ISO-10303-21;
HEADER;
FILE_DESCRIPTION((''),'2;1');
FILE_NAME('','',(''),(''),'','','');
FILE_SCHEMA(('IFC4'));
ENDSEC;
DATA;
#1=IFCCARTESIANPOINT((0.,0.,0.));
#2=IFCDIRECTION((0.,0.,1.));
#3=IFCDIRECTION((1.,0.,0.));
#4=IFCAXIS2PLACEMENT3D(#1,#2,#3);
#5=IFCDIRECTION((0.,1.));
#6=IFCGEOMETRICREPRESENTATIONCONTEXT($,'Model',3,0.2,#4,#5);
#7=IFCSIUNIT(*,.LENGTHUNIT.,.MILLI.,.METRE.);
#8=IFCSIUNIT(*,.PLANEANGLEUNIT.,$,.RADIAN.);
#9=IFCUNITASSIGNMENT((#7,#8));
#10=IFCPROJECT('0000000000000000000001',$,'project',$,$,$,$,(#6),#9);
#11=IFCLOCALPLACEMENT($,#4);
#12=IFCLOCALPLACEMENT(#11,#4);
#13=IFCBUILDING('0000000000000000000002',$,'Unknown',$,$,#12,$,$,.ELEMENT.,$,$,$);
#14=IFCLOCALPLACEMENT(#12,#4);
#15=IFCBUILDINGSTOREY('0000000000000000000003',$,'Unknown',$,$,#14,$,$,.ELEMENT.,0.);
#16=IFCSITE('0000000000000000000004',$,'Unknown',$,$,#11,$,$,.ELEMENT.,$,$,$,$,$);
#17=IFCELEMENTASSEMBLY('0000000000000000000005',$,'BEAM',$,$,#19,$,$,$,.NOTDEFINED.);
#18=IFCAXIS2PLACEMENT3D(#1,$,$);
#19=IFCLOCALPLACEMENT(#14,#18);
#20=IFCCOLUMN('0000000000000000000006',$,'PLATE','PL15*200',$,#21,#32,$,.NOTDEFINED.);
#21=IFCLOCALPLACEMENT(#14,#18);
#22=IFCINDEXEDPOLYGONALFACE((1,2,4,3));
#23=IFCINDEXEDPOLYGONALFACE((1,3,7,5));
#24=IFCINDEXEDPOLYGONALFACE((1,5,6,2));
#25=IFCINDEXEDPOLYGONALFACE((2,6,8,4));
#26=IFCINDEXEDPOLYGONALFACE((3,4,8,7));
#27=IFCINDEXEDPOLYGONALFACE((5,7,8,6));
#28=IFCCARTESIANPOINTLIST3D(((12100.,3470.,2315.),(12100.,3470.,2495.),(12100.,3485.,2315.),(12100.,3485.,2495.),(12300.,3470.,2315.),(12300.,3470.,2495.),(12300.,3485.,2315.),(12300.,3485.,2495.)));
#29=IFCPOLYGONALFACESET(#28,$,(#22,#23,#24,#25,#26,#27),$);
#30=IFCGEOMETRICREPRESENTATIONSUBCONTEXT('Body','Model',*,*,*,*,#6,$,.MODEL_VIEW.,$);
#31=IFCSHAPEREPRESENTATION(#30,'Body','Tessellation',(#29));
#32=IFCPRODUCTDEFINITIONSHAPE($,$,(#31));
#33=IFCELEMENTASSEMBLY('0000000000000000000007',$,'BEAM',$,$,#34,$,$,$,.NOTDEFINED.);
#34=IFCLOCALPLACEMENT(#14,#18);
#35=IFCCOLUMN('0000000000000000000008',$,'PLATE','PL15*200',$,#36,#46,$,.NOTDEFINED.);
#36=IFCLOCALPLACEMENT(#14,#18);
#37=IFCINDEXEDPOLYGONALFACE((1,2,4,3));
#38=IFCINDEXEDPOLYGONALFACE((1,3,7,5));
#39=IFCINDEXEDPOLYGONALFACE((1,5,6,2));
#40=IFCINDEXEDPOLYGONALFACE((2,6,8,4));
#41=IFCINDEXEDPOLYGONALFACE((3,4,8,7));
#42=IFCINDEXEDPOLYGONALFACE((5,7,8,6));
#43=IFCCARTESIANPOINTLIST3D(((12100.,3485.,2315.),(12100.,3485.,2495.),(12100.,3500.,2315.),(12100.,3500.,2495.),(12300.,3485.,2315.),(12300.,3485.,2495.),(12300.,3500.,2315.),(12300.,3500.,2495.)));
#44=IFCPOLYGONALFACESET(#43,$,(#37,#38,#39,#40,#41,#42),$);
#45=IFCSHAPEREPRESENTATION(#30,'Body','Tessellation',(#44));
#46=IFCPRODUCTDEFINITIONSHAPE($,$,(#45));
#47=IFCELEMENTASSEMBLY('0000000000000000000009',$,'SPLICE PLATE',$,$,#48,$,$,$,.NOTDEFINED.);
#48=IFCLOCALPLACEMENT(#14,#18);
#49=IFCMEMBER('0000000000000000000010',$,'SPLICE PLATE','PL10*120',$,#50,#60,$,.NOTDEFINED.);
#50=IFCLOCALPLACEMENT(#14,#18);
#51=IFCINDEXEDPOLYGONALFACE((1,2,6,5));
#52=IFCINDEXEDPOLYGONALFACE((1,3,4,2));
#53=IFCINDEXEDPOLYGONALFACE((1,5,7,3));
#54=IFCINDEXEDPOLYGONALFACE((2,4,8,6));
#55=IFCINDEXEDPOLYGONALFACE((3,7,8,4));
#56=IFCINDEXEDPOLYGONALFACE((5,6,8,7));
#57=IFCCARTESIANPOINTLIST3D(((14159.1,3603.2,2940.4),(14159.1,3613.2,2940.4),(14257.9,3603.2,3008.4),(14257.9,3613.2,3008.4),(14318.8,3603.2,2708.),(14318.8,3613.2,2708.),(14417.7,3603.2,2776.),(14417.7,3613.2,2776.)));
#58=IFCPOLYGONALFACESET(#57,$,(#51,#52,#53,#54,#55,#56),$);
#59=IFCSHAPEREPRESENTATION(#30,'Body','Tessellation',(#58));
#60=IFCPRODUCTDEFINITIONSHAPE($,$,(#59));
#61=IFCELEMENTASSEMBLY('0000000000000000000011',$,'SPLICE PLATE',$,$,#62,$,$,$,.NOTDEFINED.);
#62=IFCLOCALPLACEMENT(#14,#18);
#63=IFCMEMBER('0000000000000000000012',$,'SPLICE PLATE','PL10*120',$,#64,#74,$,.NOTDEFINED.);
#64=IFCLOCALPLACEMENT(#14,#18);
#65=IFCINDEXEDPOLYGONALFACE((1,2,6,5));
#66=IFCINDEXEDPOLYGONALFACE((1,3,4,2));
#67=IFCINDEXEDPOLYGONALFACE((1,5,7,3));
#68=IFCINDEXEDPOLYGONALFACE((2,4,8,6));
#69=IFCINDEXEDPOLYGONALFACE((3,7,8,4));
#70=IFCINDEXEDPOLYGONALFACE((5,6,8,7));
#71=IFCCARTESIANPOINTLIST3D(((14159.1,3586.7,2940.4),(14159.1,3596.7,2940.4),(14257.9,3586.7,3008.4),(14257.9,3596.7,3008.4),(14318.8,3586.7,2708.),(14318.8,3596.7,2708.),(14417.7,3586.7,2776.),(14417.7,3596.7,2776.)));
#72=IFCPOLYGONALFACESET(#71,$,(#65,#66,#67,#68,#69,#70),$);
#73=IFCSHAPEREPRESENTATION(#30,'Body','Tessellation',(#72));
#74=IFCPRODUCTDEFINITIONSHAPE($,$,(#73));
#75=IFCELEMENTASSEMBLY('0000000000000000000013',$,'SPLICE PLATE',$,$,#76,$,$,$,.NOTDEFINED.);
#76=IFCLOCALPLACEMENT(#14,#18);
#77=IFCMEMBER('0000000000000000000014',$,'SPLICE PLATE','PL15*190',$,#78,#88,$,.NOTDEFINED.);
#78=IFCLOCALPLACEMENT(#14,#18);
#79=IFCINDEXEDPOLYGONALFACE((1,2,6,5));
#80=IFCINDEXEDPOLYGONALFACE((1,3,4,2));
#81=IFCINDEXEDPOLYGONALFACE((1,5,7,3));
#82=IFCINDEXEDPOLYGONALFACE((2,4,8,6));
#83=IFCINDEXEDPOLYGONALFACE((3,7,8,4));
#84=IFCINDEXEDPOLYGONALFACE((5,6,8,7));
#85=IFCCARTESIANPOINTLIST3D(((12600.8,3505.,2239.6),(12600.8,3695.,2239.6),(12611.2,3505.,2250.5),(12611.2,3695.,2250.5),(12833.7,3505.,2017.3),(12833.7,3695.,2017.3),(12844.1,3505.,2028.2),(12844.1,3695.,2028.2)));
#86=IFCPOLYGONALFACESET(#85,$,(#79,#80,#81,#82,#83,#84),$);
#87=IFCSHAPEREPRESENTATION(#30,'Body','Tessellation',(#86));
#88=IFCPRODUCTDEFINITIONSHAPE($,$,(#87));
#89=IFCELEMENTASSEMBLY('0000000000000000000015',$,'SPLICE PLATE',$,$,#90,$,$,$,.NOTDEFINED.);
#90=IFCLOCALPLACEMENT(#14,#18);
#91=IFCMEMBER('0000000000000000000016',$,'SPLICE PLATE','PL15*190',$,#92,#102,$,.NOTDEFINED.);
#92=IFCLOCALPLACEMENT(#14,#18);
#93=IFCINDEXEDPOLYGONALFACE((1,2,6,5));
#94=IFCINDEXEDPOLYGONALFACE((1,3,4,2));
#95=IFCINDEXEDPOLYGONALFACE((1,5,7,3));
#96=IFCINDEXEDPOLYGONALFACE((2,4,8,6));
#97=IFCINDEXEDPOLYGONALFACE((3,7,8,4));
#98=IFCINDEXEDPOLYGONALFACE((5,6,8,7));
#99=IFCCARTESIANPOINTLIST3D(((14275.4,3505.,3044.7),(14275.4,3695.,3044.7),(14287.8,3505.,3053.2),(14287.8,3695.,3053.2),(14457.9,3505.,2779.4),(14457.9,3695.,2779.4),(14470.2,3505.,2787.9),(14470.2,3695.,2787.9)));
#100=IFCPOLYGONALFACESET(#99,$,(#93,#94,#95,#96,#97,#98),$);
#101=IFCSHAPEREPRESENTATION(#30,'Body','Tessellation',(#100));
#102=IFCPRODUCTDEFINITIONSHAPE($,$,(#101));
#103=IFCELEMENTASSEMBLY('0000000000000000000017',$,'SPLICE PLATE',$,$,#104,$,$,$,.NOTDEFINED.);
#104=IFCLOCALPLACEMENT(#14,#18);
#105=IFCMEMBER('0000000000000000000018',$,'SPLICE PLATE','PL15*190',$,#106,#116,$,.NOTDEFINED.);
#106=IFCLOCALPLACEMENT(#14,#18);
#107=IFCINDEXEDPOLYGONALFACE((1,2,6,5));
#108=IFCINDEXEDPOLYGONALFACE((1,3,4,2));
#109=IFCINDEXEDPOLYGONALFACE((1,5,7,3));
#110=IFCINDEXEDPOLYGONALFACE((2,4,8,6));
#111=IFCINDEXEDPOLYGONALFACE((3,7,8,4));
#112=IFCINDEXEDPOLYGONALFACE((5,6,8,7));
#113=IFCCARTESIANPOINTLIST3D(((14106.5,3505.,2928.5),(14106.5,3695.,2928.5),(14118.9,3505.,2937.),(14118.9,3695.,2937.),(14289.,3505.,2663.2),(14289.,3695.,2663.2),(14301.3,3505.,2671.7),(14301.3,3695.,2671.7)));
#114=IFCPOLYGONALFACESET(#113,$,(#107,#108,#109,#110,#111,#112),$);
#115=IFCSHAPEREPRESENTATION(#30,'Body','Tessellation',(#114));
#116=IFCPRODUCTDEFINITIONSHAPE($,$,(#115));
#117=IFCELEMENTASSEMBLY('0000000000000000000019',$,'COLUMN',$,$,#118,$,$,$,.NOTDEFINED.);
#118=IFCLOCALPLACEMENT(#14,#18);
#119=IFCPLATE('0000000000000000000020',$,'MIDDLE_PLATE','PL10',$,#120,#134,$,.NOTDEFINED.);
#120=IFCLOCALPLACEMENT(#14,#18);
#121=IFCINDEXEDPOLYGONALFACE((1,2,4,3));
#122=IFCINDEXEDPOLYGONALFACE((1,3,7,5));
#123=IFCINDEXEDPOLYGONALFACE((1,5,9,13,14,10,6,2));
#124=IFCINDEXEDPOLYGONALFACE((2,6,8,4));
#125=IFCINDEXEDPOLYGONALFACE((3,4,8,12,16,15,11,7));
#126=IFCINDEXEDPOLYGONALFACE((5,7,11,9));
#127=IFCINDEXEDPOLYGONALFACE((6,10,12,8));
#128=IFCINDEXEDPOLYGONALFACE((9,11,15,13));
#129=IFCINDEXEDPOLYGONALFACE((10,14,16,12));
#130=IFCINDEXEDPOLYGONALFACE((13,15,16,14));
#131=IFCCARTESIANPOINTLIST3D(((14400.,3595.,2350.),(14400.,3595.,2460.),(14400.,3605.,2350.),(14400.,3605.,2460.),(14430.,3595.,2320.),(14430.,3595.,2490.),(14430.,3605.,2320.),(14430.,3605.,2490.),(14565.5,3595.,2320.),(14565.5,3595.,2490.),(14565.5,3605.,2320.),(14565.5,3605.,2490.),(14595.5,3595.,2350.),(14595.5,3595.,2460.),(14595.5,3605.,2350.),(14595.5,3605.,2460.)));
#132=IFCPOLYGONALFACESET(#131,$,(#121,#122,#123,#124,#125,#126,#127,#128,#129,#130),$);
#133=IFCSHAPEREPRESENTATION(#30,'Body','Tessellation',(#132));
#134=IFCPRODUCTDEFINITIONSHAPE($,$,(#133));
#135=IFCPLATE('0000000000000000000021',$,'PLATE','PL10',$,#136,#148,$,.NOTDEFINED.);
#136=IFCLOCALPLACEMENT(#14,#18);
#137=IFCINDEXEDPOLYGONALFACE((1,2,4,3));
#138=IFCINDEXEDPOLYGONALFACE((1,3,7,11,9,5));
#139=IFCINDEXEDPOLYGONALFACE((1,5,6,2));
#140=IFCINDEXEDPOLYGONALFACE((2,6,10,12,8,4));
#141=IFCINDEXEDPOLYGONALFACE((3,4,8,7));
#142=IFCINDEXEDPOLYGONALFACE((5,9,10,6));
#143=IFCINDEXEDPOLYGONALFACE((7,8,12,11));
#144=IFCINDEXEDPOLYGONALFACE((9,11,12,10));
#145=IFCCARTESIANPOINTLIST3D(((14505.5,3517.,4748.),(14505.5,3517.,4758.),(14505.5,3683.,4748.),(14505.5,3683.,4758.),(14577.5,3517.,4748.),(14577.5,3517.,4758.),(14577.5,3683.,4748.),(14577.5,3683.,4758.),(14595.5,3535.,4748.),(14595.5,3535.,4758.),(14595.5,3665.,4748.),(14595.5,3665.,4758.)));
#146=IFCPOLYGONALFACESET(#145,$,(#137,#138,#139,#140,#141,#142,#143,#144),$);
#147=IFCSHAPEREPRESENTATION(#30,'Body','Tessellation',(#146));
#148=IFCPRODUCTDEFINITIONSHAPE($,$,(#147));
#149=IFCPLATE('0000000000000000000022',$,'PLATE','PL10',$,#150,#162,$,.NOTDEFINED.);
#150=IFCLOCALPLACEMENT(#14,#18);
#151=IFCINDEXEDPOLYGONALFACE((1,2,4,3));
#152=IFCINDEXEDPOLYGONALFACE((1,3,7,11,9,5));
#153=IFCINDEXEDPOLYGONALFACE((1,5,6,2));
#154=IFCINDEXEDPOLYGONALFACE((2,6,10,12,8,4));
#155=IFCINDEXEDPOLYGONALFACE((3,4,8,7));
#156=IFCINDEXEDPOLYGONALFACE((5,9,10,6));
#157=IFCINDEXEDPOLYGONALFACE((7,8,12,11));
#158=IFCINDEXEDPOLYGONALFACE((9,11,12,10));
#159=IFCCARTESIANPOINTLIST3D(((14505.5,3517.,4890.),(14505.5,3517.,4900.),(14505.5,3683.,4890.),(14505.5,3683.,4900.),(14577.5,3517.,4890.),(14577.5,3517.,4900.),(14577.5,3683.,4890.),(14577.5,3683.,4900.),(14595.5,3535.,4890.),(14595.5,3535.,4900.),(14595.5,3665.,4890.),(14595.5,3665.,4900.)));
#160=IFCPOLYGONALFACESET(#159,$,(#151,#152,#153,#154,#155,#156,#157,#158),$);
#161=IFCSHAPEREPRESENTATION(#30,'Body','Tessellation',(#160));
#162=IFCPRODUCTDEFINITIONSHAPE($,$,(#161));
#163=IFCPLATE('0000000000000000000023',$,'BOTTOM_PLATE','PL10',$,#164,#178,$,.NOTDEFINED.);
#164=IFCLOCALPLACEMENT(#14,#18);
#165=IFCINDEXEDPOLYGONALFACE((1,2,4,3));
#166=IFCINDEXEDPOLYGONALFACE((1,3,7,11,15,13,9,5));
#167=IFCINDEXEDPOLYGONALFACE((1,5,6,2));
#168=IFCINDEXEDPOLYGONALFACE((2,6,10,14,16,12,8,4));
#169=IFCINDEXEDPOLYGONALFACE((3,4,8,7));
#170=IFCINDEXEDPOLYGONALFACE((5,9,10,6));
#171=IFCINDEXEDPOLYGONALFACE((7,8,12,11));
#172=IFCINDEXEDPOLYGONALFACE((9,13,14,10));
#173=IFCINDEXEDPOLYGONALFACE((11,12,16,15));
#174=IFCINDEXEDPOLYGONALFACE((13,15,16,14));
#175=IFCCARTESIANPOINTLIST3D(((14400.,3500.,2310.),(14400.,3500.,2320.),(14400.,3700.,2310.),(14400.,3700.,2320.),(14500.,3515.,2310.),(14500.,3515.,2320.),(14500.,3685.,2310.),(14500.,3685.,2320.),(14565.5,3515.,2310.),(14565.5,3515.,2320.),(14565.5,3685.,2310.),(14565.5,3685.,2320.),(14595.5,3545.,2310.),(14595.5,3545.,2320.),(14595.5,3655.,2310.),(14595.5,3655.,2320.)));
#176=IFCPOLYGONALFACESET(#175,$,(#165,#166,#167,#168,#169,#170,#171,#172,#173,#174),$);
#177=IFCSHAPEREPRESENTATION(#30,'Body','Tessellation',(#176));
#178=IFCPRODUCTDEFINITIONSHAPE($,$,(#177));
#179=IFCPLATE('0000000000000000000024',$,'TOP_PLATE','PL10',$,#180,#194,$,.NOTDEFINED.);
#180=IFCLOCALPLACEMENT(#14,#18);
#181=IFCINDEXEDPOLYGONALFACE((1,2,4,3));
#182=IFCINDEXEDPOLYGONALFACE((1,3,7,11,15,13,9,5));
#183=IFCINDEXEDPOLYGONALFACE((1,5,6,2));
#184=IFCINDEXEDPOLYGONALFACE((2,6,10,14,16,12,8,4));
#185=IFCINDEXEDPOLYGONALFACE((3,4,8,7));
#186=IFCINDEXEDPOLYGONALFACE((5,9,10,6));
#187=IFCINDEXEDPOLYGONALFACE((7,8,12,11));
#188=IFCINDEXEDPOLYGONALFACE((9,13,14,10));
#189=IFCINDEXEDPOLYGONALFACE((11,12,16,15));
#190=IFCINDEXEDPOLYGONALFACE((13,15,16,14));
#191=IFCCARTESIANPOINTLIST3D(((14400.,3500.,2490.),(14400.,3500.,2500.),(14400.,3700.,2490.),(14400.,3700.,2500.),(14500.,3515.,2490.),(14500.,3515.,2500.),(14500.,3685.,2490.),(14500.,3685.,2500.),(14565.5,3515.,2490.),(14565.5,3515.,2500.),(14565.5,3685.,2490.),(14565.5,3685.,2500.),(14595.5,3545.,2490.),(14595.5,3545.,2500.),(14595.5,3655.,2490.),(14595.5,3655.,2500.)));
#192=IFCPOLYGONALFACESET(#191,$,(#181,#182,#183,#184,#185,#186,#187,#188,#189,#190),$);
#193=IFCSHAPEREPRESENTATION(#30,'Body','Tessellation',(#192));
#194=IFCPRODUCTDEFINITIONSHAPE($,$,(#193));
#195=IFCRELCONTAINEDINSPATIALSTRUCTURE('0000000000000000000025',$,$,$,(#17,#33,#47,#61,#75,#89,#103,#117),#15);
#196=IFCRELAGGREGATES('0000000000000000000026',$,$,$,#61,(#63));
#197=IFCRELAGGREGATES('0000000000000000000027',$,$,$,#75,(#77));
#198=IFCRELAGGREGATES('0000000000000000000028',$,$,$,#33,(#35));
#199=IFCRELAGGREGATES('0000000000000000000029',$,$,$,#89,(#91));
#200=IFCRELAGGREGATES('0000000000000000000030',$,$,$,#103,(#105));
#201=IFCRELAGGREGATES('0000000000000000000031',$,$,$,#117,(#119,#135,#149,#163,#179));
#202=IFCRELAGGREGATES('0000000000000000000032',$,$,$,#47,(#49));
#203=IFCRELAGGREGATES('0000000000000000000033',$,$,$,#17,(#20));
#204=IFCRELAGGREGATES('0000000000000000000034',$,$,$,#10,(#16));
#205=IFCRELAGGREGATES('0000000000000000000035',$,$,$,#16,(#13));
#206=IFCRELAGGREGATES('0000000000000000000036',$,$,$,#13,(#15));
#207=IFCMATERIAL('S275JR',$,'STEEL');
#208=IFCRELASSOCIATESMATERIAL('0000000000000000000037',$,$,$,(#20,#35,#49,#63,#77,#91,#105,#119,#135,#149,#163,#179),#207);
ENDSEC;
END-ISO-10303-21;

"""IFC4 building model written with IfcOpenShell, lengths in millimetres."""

from ifc_helpers import new_model, si_unit, direction, frame, origin_with_axes, place, context, subcontext, project, spatial, line, indexed_curve, outline, extrude, material, element, aggregate, save


model = new_model("IFC4")

# Units and contexts
model_context = context("Model", 3, precision=0.2, world=origin_with_axes(), true_north=direction((0.0, 1.0)))
body_context = subcontext(model_context, "Body", "Model", "MODEL_VIEW")
ifc_project = project(units=[si_unit("LENGTHUNIT", "METRE", prefix="MILLI"), si_unit("PLANEANGLEUNIT", "RADIAN")], contexts=[model_context])

# Site, building, storey
site_placement = place(None, origin_with_axes())
site = spatial("IfcSite", under=ifc_project, at=site_placement, Name="Unknown", CompositionType="ELEMENT")
building_placement = place(site_placement, origin_with_axes())
building = spatial("IfcBuilding", under=site, at=building_placement, Name="Unknown", CompositionType="ELEMENT")
storey_placement = place(building_placement, origin_with_axes())
storey = spatial("IfcBuildingStorey", under=building, at=storey_placement, Name="Unknown", CompositionType="ELEMENT", Elevation=0.0)

# Element assemblies, columns
assembly_1_placement = place(storey_placement, frame((12200.0, 100.0, 2405.0), z_axis=(1.0, 0.0, 0.0), x_axis=(0.0, 1.0, 0.0)))
assembly_1 = element("IfcElementAssembly", 1, at=assembly_1_placement, inside=storey, Name="BEAM", PredefinedType="NOTDEFINED")
ifc_material_1 = material(Name="S275JR", Category="STEEL")
column_1_placement = place(assembly_1_placement, frame((3377.5, -90.0, 0.0), z_axis=(-1.0, 0.0, 0.0), x_axis=(0.0, 1.0, 0.0)))
column_1 = element("IfcColumn", 2, at=column_1_placement, material=ifc_material_1, Name="PLATE", Description="PL15*200", PredefinedType="NOTDEFINED", context=body_context, shape_type="SolidModel", body=[
    extrude(outline(indexed_curve([(-7.5, -100.0), (7.5, -100.0), (7.5, 100.0), (-7.5, 100.0)], segments=[line(1, 2, 3, 4, 1)])), frame((0.0, 0.0, 0.0), z_axis=(-1.0, 0.0, 0.0), x_axis=(0.0, 0.0, 1.0)), (0.0, -0.000002, -1.0), 180.0),
])
assembly_2_placement = place(storey_placement, frame((9800.0, 3600.0, 2405.0), z_axis=(-0.000002, -1.0, 0.0), x_axis=(1.0, 0.0, 0.0)))
assembly_2 = element("IfcElementAssembly", 3, at=assembly_2_placement, inside=storey, Name="BEAM", PredefinedType="NOTDEFINED")
column_2_placement = place(assembly_2_placement, frame((2400.0, -90.0, 107.5), z_axis=(0.0, 0.0, 1.0), x_axis=(0.0, 1.0, 0.0)))
column_2 = element("IfcColumn", 4, at=column_2_placement, material=ifc_material_1, Name="PLATE", Description="PL15*200", PredefinedType="NOTDEFINED", context=body_context, shape_type="SolidModel", body=[
    extrude(outline(indexed_curve([(-7.5, -100.0), (7.5, -100.0), (7.5, 100.0), (-7.5, 100.0)], segments=[line(1, 2, 3, 4, 1)])), frame((0.0, 0.0, 0.0), z_axis=(-1.0, 0.0, 0.0), x_axis=(0.0, 0.0, 1.0)), (0.0, -0.000002, -1.0), 180.0),
])

# Element assemblies, members
assembly_3_placement = place(storey_placement, frame((14368.3, 3608.2, 2742.0), z_axis=(0.0, 1.0, 0.0), x_axis=(-0.566581, 0.0, 0.824006)))
assembly_3 = element("IfcElementAssembly", 5, at=assembly_3_placement, inside=storey, Name="SPLICE PLATE", PredefinedType="NOTDEFINED")
member_1_placement = place(assembly_3_placement, origin_with_axes())
member_1 = element("IfcMember", 6, at=member_1_placement, material=ifc_material_1, Name="SPLICE PLATE", Description="PL10*120", PredefinedType="NOTDEFINED", context=body_context, shape_type="SolidModel", body=[
    extrude(outline(indexed_curve([(-5.0, -60.0), (5.0, -60.0), (5.0, 60.0), (-5.0, 60.0)], segments=[line(1, 2, 3, 4, 1)])), frame((0.0, 0.0, 0.0), z_axis=(-1.0, 0.0, 0.0), x_axis=(0.0, 0.0, 1.0)), (0.0, -0.000002, -1.0), 282.0),
])
assembly_4_placement = place(storey_placement, frame((14368.3, 3591.7, 2742.0), z_axis=(0.0, 1.0, 0.0), x_axis=(-0.566581, 0.0, 0.824006)))
assembly_4 = element("IfcElementAssembly", 7, at=assembly_4_placement, inside=storey, Name="SPLICE PLATE", PredefinedType="NOTDEFINED")
member_2_placement = place(assembly_4_placement, origin_with_axes())
member_2 = element("IfcMember", 8, at=member_2_placement, material=ifc_material_1, Name="SPLICE PLATE", Description="PL10*120", PredefinedType="NOTDEFINED", context=body_context, shape_type="SolidModel", body=[
    extrude(outline(indexed_curve([(-5.0, -60.0), (5.0, -60.0), (5.0, 60.0), (-5.0, 60.0)], segments=[line(1, 2, 3, 4, 1)])), frame((0.0, 0.0, 0.0), z_axis=(-1.0, 0.0, 0.0), x_axis=(0.0, 0.0, 1.0)), (0.0, -0.000002, -1.0), 282.0),
])
aggregate(assembly_4, [member_2])
assembly_5_placement = place(storey_placement, frame((12606.0, 3600.0, 2245.1), z_axis=(-0.690476, 0.0, -0.723355), x_axis=(0.723355, 0.0, -0.690476)))
assembly_5 = element("IfcElementAssembly", 9, at=assembly_5_placement, inside=storey, Name="SPLICE PLATE", PredefinedType="NOTDEFINED")
member_3_placement = place(assembly_5_placement, origin_with_axes())
member_3 = element("IfcMember", 10, at=member_3_placement, material=ifc_material_1, Name="SPLICE PLATE", Description="PL15*190", PredefinedType="NOTDEFINED", context=body_context, shape_type="SolidModel", body=[
    extrude(outline(indexed_curve([(-7.5, -95.0), (7.5, -95.0), (7.5, 95.0), (-7.5, 95.0)], segments=[line(1, 2, 3, 4, 1)])), frame((0.0, 0.0, 0.0), z_axis=(-1.0, 0.0, 0.0), x_axis=(0.0, 0.0, 1.0)), (0.0, -0.000002, -1.0), 322.0),
])
aggregate(assembly_5, [member_3])
assembly_6_placement = place(storey_placement, frame((14464.1, 3600.0, 2783.6), z_axis=(-0.824006, 0.0, -0.566581), x_axis=(-0.566581, 0.0, 0.824006)))
assembly_6 = element("IfcElementAssembly", 11, at=assembly_6_placement, inside=storey, Name="SPLICE PLATE", PredefinedType="NOTDEFINED")
member_4_placement = place(assembly_6_placement, origin_with_axes())
member_4 = element("IfcMember", 12, at=member_4_placement, material=ifc_material_1, Name="SPLICE PLATE", Description="PL15*190", PredefinedType="NOTDEFINED", context=body_context, shape_type="SolidModel", body=[
    extrude(outline(indexed_curve([(-7.5, -95.0), (7.5, -95.0), (7.5, 95.0), (-7.5, 95.0)], segments=[line(1, 2, 3, 4, 1)])), frame((0.0, 0.0, 0.0), z_axis=(-1.0, 0.0, 0.0), x_axis=(0.0, 0.0, 1.0)), (0.0, -0.000002, -1.0), 322.0),
])
assembly_7_placement = place(storey_placement, frame((14295.1, 3600.0, 2667.5), z_axis=(-0.824006, 0.0, -0.566581), x_axis=(-0.566581, 0.0, 0.824006)))
assembly_7 = element("IfcElementAssembly", 13, at=assembly_7_placement, inside=storey, Name="SPLICE PLATE", PredefinedType="NOTDEFINED")
member_5_placement = place(assembly_7_placement, origin_with_axes())
member_5 = element("IfcMember", 14, at=member_5_placement, material=ifc_material_1, Name="SPLICE PLATE", Description="PL15*190", PredefinedType="NOTDEFINED", context=body_context, shape_type="SolidModel", body=[
    extrude(outline(indexed_curve([(-7.5, -95.0), (7.5, -95.0), (7.5, 95.0), (-7.5, 95.0)], segments=[line(1, 2, 3, 4, 1)])), frame((0.0, 0.0, 0.0), z_axis=(-1.0, 0.0, 0.0), x_axis=(0.0, 0.0, 1.0)), (0.0, -0.000002, -1.0), 322.0),
])

# Element assembly, plates
assembly_8_placement = place(storey_placement, frame((14600.0, 3600.0, 200.0), z_axis=(-1.0, 0.0, 0.0), x_axis=(0.0, 0.0, 1.0)))
assembly_8 = element("IfcElementAssembly", 15, at=assembly_8_placement, inside=storey, Name="COLUMN", PredefinedType="NOTDEFINED")
plate_1_placement = place(assembly_8_placement, frame((2290.0, 0.0, 200.0), z_axis=(0.0, 1.0, 0.0), x_axis=(0.0, -0.000002, -1.0)))
plate_1 = element("IfcPlate", 16, at=plate_1_placement, material=ifc_material_1, Name="MIDDLE_PLATE", Description="PL10", PredefinedType="NOTDEFINED", context=body_context, shape_type="SolidModel", body=[
    extrude(outline(indexed_curve([(0.0, 30.0), (30.0, 0.0), (165.5, 0.0), (195.5, 30.0), (195.5, 140.0), (165.5, 170.0), (30.0, 170.0), (0.0, 140.0)], segments=[line(1, 2, 3, 4, 5, 6, 7, 8, 1)])), frame((0.0, 0.0, 5.0), z_axis=(0.0, 0.0, 1.0), x_axis=(1.0, 0.0, 0.0)), (0.0, -0.000002, -1.0), 10.0),
])
plate_2_placement = place(assembly_8_placement, frame((4553.0, -83.0, 4.5), z_axis=(-1.0, 0.0, 0.0), x_axis=(0.0, 0.0, 1.0)))
plate_2 = element("IfcPlate", 17, at=plate_2_placement, material=ifc_material_1, Name="PLATE", Description="PL10", PredefinedType="NOTDEFINED", context=body_context, shape_type="SolidModel", body=[
    extrude(outline(indexed_curve([(0.0, 18.0), (18.0, 0.0), (90.0, 0.0), (90.0, 166.0), (18.0, 166.0), (0.0, 148.0)], segments=[line(1, 2, 3, 4, 5, 6, 1)])), frame((0.0, 0.0, 5.0), z_axis=(0.0, 0.0, 1.0), x_axis=(1.0, 0.0, 0.0)), (0.0, -0.000002, -1.0), 10.0),
])
plate_3_placement = place(assembly_8_placement, frame((4695.0, -83.0, 4.5), z_axis=(-1.0, 0.0, 0.0), x_axis=(0.0, 0.0, 1.0)))
plate_3 = element("IfcPlate", 18, at=plate_3_placement, material=ifc_material_1, Name="PLATE", Description="PL10", PredefinedType="NOTDEFINED", context=body_context, shape_type="SolidModel", body=[
    extrude(outline(indexed_curve([(0.0, 18.0), (18.0, 0.0), (90.0, 0.0), (90.0, 166.0), (18.0, 166.0), (0.0, 148.0)], segments=[line(1, 2, 3, 4, 5, 6, 1)])), frame((0.0, 0.0, 5.0), z_axis=(0.0, 0.0, 1.0), x_axis=(1.0, 0.0, 0.0)), (0.0, -0.000002, -1.0), 10.0),
])
plate_4_placement = place(assembly_8_placement, frame((2115.0, -85.0, 4.5), z_axis=(1.0, 0.0, 0.0), x_axis=(0.0, 1.0, 0.0)))
plate_4 = element("IfcPlate", 19, at=plate_4_placement, material=ifc_material_1, Name="BOTTOM_PLATE", Description="PL10", PredefinedType="NOTDEFINED", context=body_context, shape_type="SolidModel", body=[
    extrude(outline(indexed_curve([(0.0, 30.0), (30.0, 0.0), (140.0, 0.0), (170.0, 30.0), (170.0, 95.5), (185.0, 195.5), (-15.0, 195.5), (0.0, 95.5)], segments=[line(1, 2, 3, 4, 5, 6, 7, 8, 1)])), frame((0.0, 0.0, 5.0), z_axis=(0.0, 0.0, 1.0), x_axis=(1.0, 0.0, 0.0)), (0.0, -0.000002, -1.0), 10.0),
])
plate_5_placement = place(assembly_8_placement, frame((2295.0, -85.0, 100.0), z_axis=(1.0, 0.0, 0.0), x_axis=(0.0, -0.000002, -1.0)))
plate_5 = element("IfcPlate", 20, at=plate_5_placement, material=ifc_material_1, Name="TOP_PLATE", Description="PL10", PredefinedType="NOTDEFINED", context=body_context, shape_type="SolidModel", body=[
    extrude(outline(indexed_curve([(0.0, 0.0), (65.5, 0.0), (95.5, 30.0), (95.5, 140.0), (65.5, 170.0), (0.0, 170.0), (-100.0, 185.0), (-100.0, -15.0)], segments=[line(1, 2, 3, 4, 5, 6, 7, 8, 1)])), frame((0.0, 0.0, 5.0), z_axis=(0.0, 0.0, 1.0), x_axis=(1.0, 0.0, 0.0)), (0.0, -0.000002, -1.0), 10.0),
])

aggregate(assembly_2, [column_2])
aggregate(assembly_6, [member_4])
aggregate(assembly_7, [member_5])
aggregate(assembly_8, [plate_1, plate_2, plate_3, plate_4, plate_5])
aggregate(assembly_3, [member_1])
aggregate(assembly_1, [column_1])

save(model, "model.ifc")
